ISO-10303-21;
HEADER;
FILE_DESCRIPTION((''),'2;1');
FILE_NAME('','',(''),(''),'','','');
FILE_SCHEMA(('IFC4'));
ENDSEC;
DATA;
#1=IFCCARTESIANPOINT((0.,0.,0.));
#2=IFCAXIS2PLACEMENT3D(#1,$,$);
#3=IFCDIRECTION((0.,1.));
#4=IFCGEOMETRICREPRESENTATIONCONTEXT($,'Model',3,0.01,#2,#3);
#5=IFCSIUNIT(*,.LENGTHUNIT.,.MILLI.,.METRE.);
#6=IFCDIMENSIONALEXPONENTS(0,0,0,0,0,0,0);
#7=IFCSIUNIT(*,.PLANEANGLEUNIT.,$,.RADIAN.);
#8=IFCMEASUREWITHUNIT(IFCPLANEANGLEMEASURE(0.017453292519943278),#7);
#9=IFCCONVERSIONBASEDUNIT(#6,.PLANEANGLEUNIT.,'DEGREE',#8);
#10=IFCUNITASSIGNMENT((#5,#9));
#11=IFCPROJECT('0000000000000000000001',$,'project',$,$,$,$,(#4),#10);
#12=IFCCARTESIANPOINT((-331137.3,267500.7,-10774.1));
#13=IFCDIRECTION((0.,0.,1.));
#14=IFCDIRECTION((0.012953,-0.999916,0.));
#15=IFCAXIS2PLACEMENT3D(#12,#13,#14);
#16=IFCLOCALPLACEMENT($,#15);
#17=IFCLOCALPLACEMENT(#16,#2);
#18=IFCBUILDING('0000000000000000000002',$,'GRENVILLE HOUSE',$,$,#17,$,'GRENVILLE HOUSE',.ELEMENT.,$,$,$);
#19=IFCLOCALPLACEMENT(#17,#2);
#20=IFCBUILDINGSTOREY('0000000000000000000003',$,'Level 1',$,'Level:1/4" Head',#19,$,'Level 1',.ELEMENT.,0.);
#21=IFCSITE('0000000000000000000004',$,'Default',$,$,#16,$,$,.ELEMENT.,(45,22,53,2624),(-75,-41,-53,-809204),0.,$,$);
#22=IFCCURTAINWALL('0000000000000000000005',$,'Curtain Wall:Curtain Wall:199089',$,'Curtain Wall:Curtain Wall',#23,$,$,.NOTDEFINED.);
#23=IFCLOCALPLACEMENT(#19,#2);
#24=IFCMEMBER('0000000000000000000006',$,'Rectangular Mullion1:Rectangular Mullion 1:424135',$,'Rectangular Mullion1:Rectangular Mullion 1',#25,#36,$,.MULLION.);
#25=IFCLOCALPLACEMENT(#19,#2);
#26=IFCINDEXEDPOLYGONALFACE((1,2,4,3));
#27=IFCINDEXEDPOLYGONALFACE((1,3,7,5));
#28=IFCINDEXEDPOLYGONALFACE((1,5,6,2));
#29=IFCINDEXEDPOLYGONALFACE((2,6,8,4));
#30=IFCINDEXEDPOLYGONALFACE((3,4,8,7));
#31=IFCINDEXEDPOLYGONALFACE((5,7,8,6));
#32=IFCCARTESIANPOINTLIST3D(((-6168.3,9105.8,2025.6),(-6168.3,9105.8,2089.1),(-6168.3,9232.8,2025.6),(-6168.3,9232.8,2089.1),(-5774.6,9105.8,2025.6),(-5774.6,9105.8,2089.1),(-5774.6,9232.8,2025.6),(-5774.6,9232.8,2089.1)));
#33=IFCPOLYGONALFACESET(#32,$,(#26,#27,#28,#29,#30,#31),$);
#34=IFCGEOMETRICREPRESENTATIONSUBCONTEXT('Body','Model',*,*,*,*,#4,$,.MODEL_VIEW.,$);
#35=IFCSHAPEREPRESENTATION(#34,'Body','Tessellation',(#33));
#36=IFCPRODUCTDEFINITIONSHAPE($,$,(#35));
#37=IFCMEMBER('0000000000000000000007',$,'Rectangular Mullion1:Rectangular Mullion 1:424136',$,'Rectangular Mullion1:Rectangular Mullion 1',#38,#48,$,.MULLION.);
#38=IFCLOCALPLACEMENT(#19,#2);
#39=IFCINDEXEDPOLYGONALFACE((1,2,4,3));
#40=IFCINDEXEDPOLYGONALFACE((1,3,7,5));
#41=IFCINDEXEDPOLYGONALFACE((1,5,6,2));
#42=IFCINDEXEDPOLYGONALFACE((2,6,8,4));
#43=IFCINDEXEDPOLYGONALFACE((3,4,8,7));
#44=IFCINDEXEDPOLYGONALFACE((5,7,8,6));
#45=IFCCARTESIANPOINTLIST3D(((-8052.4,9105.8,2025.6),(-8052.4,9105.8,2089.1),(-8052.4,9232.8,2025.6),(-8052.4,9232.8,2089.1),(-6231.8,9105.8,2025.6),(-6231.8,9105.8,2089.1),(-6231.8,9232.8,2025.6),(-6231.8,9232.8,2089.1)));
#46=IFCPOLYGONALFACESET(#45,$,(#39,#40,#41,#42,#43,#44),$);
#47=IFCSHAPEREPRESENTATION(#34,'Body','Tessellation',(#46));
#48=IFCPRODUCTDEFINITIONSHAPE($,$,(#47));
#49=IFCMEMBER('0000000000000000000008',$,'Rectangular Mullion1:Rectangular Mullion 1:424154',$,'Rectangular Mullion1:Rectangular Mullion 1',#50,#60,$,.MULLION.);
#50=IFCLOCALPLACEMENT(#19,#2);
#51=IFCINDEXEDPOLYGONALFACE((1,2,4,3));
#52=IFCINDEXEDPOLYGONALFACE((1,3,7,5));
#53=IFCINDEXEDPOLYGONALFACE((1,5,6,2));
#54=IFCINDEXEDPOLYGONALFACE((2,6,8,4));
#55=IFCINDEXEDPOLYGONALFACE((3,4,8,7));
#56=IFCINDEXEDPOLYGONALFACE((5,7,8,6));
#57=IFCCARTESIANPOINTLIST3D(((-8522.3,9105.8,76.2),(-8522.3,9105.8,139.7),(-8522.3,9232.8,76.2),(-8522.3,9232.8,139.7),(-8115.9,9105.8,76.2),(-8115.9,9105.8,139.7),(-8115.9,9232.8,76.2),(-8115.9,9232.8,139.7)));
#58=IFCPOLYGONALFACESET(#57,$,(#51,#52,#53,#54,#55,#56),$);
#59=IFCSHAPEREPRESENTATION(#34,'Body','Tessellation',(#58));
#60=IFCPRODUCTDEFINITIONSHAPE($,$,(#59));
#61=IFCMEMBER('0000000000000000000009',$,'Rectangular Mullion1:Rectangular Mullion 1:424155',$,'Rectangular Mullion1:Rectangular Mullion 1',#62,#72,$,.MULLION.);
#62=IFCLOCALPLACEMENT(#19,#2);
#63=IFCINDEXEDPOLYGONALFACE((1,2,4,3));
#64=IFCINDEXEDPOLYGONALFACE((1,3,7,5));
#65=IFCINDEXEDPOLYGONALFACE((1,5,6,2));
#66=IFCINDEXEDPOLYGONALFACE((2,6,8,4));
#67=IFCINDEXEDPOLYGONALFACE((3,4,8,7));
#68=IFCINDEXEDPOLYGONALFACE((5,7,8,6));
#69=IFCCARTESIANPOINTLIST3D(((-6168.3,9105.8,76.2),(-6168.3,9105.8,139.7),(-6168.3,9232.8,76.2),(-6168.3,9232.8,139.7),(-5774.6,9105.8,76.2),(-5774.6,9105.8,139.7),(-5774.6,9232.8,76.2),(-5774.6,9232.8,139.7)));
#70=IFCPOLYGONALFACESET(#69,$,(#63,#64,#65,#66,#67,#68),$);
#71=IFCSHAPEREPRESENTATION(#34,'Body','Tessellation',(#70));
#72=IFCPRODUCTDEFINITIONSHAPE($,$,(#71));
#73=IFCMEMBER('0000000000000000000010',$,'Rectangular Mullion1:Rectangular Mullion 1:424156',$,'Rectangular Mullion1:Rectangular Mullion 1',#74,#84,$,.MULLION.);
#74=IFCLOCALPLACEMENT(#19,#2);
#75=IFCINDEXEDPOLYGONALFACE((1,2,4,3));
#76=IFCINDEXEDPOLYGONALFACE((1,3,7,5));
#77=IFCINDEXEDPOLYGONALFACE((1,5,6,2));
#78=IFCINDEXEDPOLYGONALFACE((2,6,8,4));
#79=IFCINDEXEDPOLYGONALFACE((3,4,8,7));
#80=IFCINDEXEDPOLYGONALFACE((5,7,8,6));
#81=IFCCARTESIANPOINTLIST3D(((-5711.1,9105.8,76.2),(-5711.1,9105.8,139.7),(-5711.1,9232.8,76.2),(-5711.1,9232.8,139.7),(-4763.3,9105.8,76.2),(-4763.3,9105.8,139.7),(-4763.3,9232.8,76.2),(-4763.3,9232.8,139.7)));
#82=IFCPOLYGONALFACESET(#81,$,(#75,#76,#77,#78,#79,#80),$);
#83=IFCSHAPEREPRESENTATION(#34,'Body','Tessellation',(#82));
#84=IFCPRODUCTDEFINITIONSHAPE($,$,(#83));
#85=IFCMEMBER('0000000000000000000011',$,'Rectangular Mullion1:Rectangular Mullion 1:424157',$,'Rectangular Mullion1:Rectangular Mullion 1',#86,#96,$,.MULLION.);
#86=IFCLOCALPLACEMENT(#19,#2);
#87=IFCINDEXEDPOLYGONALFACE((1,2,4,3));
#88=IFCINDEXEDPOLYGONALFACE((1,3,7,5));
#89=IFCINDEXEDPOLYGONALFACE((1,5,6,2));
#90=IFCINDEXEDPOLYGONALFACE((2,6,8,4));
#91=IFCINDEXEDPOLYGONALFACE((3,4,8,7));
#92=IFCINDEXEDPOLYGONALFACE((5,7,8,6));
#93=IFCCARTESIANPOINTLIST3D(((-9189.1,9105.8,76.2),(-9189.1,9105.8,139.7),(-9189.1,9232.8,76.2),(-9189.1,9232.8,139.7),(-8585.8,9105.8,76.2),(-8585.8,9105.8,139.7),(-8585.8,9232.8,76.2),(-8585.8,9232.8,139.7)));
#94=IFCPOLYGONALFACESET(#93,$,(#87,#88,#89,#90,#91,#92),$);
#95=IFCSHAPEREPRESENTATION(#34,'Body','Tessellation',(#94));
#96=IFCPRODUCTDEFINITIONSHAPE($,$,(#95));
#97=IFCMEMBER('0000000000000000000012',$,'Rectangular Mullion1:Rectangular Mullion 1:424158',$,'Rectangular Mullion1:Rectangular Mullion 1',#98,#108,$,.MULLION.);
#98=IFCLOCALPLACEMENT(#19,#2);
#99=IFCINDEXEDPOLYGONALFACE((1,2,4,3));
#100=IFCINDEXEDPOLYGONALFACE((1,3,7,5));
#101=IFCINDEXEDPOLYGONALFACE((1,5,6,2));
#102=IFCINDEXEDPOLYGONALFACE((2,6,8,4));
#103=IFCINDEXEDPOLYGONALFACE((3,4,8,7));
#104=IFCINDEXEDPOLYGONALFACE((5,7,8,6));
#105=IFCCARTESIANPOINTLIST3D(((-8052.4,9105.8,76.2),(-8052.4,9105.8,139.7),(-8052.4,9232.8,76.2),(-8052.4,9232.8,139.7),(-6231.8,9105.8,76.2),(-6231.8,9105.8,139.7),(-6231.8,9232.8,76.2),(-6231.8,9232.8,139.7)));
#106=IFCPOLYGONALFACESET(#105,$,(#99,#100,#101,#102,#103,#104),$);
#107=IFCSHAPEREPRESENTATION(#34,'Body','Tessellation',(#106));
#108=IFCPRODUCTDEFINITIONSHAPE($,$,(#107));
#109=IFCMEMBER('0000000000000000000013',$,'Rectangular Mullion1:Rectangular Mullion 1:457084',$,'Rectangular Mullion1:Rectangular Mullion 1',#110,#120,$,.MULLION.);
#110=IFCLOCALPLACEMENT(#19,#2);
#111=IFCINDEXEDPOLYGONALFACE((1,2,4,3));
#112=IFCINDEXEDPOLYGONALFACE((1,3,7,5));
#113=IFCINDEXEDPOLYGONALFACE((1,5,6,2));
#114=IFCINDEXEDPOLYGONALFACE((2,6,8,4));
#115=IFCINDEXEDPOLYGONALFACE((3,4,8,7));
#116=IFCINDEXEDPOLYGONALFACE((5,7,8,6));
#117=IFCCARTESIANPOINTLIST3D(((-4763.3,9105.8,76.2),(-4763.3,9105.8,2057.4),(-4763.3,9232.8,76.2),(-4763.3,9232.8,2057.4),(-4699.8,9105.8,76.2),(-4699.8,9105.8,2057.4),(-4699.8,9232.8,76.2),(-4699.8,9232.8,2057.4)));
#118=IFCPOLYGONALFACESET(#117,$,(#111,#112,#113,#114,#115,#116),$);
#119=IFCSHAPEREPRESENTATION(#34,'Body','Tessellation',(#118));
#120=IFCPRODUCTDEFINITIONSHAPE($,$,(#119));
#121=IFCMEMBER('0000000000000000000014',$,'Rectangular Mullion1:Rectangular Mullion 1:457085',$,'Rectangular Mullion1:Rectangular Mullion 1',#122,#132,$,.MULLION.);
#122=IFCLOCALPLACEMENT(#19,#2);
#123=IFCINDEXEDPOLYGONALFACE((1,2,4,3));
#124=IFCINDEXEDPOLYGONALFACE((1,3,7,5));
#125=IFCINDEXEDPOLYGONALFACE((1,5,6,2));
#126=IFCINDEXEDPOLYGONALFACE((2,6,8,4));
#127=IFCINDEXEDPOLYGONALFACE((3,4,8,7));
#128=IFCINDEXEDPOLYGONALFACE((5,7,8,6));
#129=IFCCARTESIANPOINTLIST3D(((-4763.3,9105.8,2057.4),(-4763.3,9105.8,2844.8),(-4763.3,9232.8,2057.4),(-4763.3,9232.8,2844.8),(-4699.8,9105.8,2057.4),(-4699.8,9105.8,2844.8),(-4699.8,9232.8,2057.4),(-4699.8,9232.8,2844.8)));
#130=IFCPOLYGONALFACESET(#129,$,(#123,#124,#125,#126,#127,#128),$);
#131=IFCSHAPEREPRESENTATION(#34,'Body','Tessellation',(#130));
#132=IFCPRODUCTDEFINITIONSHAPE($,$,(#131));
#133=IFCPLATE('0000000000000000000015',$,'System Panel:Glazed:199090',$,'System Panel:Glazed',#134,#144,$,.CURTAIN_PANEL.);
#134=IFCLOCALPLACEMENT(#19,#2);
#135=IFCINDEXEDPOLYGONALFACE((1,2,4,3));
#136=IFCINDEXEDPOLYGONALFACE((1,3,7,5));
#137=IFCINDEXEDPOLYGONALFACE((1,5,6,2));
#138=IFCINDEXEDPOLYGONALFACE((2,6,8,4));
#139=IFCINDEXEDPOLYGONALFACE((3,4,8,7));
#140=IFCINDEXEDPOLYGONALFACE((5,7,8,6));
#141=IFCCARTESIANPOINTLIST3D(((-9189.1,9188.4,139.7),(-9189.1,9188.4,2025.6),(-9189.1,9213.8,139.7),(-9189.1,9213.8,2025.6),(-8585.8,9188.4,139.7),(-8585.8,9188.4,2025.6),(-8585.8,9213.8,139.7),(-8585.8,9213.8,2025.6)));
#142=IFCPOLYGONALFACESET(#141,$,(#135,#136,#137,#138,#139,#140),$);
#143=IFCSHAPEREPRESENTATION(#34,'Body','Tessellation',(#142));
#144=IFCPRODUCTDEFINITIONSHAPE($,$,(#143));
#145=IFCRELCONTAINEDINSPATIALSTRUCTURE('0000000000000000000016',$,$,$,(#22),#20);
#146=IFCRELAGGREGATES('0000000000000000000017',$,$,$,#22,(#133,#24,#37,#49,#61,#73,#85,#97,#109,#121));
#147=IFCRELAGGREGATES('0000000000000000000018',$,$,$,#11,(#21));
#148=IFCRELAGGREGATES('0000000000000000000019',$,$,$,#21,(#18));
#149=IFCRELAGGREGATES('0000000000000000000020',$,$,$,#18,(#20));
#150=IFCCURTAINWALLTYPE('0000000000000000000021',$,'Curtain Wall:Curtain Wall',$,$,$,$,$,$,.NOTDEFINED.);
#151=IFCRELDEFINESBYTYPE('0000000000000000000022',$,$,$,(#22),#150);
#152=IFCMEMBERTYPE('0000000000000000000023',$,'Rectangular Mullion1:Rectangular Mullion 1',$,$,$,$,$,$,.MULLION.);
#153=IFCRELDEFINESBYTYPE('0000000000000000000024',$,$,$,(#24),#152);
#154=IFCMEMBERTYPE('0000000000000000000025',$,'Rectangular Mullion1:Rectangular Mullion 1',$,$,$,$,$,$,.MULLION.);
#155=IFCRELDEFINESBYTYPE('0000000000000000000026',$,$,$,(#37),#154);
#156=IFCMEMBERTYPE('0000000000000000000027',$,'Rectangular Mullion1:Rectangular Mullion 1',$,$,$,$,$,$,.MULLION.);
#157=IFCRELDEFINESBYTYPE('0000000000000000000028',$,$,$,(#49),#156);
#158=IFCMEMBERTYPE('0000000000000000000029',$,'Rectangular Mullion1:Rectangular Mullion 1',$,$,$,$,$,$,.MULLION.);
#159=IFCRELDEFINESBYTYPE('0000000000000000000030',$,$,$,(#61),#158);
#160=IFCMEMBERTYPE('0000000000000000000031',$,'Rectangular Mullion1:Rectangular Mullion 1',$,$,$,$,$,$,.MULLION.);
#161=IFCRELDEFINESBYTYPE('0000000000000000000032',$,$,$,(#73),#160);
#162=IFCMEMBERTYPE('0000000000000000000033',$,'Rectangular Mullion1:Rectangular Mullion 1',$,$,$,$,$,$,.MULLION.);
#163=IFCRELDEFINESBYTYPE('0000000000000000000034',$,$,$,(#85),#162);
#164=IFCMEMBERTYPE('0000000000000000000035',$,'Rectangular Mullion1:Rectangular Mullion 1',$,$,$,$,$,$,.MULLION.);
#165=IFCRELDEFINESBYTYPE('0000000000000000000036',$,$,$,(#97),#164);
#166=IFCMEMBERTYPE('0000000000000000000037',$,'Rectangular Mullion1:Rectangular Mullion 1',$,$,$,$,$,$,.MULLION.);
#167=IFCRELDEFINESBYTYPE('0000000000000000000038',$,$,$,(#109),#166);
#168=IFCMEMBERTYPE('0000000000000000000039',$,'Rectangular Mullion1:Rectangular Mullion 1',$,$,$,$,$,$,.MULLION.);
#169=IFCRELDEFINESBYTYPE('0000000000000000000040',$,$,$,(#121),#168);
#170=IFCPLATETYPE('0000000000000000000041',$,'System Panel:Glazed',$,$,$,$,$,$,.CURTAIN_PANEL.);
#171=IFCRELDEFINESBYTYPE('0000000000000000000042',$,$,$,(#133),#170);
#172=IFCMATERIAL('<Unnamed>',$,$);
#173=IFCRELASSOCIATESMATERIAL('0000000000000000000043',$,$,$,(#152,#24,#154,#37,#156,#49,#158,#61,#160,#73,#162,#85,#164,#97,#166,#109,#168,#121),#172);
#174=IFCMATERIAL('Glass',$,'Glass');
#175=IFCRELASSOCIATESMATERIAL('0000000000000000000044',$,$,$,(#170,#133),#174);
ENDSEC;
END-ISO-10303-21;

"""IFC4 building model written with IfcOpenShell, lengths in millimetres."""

from ifc_helpers import new_model, entity, si_unit, converted_unit, direction, frame, origin, place, context, subcontext, project, spatial, indexed_curve, outline, extrude, source, transform, mapped, material, type_object, type_shapes, element, aggregate, save


model = new_model("IFC4")

# Units and contexts
model_context = context("Model", 3, precision=0.01, world=origin(), true_north=direction((0.0, 1.0)))
body_context = subcontext(model_context, "Body", "Model", "MODEL_VIEW")
ifc_project = project(units=[si_unit("LENGTHUNIT", "METRE", prefix="MILLI"), converted_unit("PLANEANGLEUNIT", "DEGREE", entity("IfcPlaneAngleMeasure", 0.017453292519943278), si_unit("PLANEANGLEUNIT", "RADIAN"), dimensions=[0, 0, 0, 0, 0, 0, 0])], contexts=[model_context])

# Site, building, storey
site_placement = place(None, frame((-331137.3, 267500.7, -10774.1), z_axis=(0.0, 0.0, 1.0), x_axis=(0.012953, -0.999916, 0.0)))
site = spatial("IfcSite", under=ifc_project, at=site_placement, Name="Default", CompositionType="ELEMENT", RefLatitude=(45, 22, 53, 2624), RefLongitude=(-75, -41, -53, -809204), RefElevation=0.0)
building_placement = place(site_placement, origin())
building = spatial("IfcBuilding", under=site, at=building_placement, Name="GRENVILLE HOUSE", LongName="GRENVILLE HOUSE", CompositionType="ELEMENT")
storey_placement = place(building_placement, origin())
storey = spatial("IfcBuildingStorey", under=building, at=storey_placement, Name="Level 1", ObjectType="Level:1/4\" Head", LongName="Level 1", CompositionType="ELEMENT", Elevation=0.0)

# Shared definitions
curtain_wall_type = type_object("IfcCurtainWallType", Name="Curtain Wall:Curtain Wall", PredefinedType="NOTDEFINED")
ifc_material_1 = material(Name="<Unnamed>")

# Curtain wall, members, plate
curtain_wall_1_placement = place(storey_placement, origin())
curtain_wall_1 = element("IfcCurtainWall", 1, at=curtain_wall_1_placement, inside=storey, type_object=curtain_wall_type, Name="Curtain Wall:Curtain Wall:199089", ObjectType="Curtain Wall:Curtain Wall", PredefinedType="NOTDEFINED")
member_type_1 = type_object("IfcMemberType", Name="Rectangular Mullion1:Rectangular Mullion 1", PredefinedType="MULLION", material=ifc_material_1)
shared_shape_1 = source(origin(), body_context, "Body", "SweptSolid", [
    extrude(outline(indexed_curve([(-31.8, -63.5), (31.8, -63.5), (31.8, 63.5), (-31.8, 63.5), (-31.8, -63.5)], self_intersect=False)), frame((0.0, 0.0, -393.7), z_axis=(0.0, 0.0, 1.0), x_axis=(-1.0, 0.0, 0.0)), (0.0, 0.0, 1.0), 393.7),
])
type_shapes(member_type_1, [shared_shape_1])
member_1_placement = place(curtain_wall_1_placement, frame((-5774.6, 9169.3, 2057.4), z_axis=(1.0, 0.0, 0.0), x_axis=(0.0, 0.0, 1.0)))
member_1 = element("IfcMember", 2, at=member_1_placement, type_object=member_type_1, material=ifc_material_1, Name="Rectangular Mullion1:Rectangular Mullion 1:424135", ObjectType="Rectangular Mullion1:Rectangular Mullion 1", PredefinedType="MULLION", context=body_context, shape_type="MappedRepresentation", body=[
    mapped(shared_shape_1, transform((0.0, 0.0, 0.0), scale=1.0)),
])
member_type_2 = type_object("IfcMemberType", Name="Rectangular Mullion1:Rectangular Mullion 1", PredefinedType="MULLION", material=ifc_material_1)
shared_shape_2 = source(origin(), body_context, "Body", "SweptSolid", [
    extrude(outline(indexed_curve([(-31.8, -63.5), (31.8, -63.5), (31.8, 63.5), (-31.8, 63.5), (-31.8, -63.5)], self_intersect=False)), frame((0.0, 0.0, -1820.6), z_axis=(0.0, 0.0, 1.0), x_axis=(-1.0, 0.0, 0.0)), (0.0, 0.0, 1.0), 1820.6),
])
type_shapes(member_type_2, [shared_shape_2])
member_2_placement = place(curtain_wall_1_placement, frame((-6231.8, 9169.3, 2057.4), z_axis=(1.0, 0.0, 0.0), x_axis=(0.0, 0.0, 1.0)))
member_2 = element("IfcMember", 3, at=member_2_placement, type_object=member_type_2, material=ifc_material_1, Name="Rectangular Mullion1:Rectangular Mullion 1:424136", ObjectType="Rectangular Mullion1:Rectangular Mullion 1", PredefinedType="MULLION", context=body_context, shape_type="MappedRepresentation", body=[
    mapped(shared_shape_2, transform((0.0, 0.0, 0.0), scale=1.0)),
])
member_type_3 = type_object("IfcMemberType", Name="Rectangular Mullion1:Rectangular Mullion 1", PredefinedType="MULLION", material=ifc_material_1)
shared_shape_3 = source(origin(), body_context, "Body", "SweptSolid", [
    extrude(outline(indexed_curve([(-31.8, -63.5), (31.8, -63.5), (31.8, 63.5), (-31.8, 63.5), (-31.8, -63.5)], self_intersect=False)), frame((-31.8, 0.0, -406.4), z_axis=(0.0, 0.0, 1.0), x_axis=(-1.0, 0.0, 0.0)), (0.0, 0.0, 1.0), 406.4),
])
type_shapes(member_type_3, [shared_shape_3])
member_3_placement = place(curtain_wall_1_placement, frame((-8522.3, 9169.3, 76.2), z_axis=(-1.0, 0.0, 0.0), x_axis=(0.0, 0.0, -1.0)))
member_3 = element("IfcMember", 4, at=member_3_placement, type_object=member_type_3, material=ifc_material_1, Name="Rectangular Mullion1:Rectangular Mullion 1:424154", ObjectType="Rectangular Mullion1:Rectangular Mullion 1", PredefinedType="MULLION", context=body_context, shape_type="MappedRepresentation", body=[
    mapped(shared_shape_3, transform((0.0, 0.0, 0.0), scale=1.0)),
])
member_type_4 = type_object("IfcMemberType", Name="Rectangular Mullion1:Rectangular Mullion 1", PredefinedType="MULLION", material=ifc_material_1)
shared_shape_4 = source(origin(), body_context, "Body", "SweptSolid", [
    extrude(outline(indexed_curve([(-31.8, -63.5), (31.8, -63.5), (31.8, 63.5), (-31.8, 63.5), (-31.8, -63.5)], self_intersect=False)), frame((-31.8, 0.0, -393.7), z_axis=(0.0, 0.0, 1.0), x_axis=(-1.0, 0.0, 0.0)), (0.0, 0.0, 1.0), 393.7),
])
type_shapes(member_type_4, [shared_shape_4])
member_4_placement = place(curtain_wall_1_placement, frame((-6168.3, 9169.3, 76.2), z_axis=(-1.0, 0.0, 0.0), x_axis=(0.0, 0.0, -1.0)))
member_4 = element("IfcMember", 5, at=member_4_placement, type_object=member_type_4, material=ifc_material_1, Name="Rectangular Mullion1:Rectangular Mullion 1:424155", ObjectType="Rectangular Mullion1:Rectangular Mullion 1", PredefinedType="MULLION", context=body_context, shape_type="MappedRepresentation", body=[
    mapped(shared_shape_4, transform((0.0, 0.0, 0.0), scale=1.0)),
])
member_type_5 = type_object("IfcMemberType", Name="Rectangular Mullion1:Rectangular Mullion 1", PredefinedType="MULLION", material=ifc_material_1)
shared_shape_5 = source(origin(), body_context, "Body", "SweptSolid", [
    extrude(outline(indexed_curve([(-31.8, -63.5), (31.8, -63.5), (31.8, 63.5), (-31.8, 63.5), (-31.8, -63.5)], self_intersect=False)), frame((-31.8, 0.0, -947.7), z_axis=(0.0, 0.0, 1.0), x_axis=(-1.0, 0.0, 0.0)), (0.0, 0.0, 1.0), 947.7),
])
type_shapes(member_type_5, [shared_shape_5])
member_5_placement = place(curtain_wall_1_placement, frame((-5711.1, 9169.3, 76.2), z_axis=(-1.0, 0.0, 0.0), x_axis=(0.0, 0.0, -1.0)))
member_5 = element("IfcMember", 6, at=member_5_placement, type_object=member_type_5, material=ifc_material_1, Name="Rectangular Mullion1:Rectangular Mullion 1:424156", ObjectType="Rectangular Mullion1:Rectangular Mullion 1", PredefinedType="MULLION", context=body_context, shape_type="MappedRepresentation", body=[
    mapped(shared_shape_5, transform((0.0, 0.0, 0.0), scale=1.0)),
])
member_type_6 = type_object("IfcMemberType", Name="Rectangular Mullion1:Rectangular Mullion 1", PredefinedType="MULLION", material=ifc_material_1)
shared_shape_6 = source(origin(), body_context, "Body", "SweptSolid", [
    extrude(outline(indexed_curve([(-31.8, -63.5), (31.8, -63.5), (31.8, 63.5), (-31.8, 63.5), (-31.8, -63.5)], self_intersect=False)), frame((-31.8, 0.0, -603.3), z_axis=(0.0, 0.0, 1.0), x_axis=(-1.0, 0.0, 0.0)), (0.0, 0.0, 1.0), 603.3),
])
type_shapes(member_type_6, [shared_shape_6])
member_6_placement = place(curtain_wall_1_placement, frame((-9189.1, 9169.3, 76.2), z_axis=(-1.0, 0.0, 0.0), x_axis=(0.0, 0.0, -1.0)))
member_6 = element("IfcMember", 7, at=member_6_placement, type_object=member_type_6, material=ifc_material_1, Name="Rectangular Mullion1:Rectangular Mullion 1:424157", ObjectType="Rectangular Mullion1:Rectangular Mullion 1", PredefinedType="MULLION", context=body_context, shape_type="MappedRepresentation", body=[
    mapped(shared_shape_6, transform((0.0, 0.0, 0.0), scale=1.0)),
])
member_type_7 = type_object("IfcMemberType", Name="Rectangular Mullion1:Rectangular Mullion 1", PredefinedType="MULLION", material=ifc_material_1)
shared_shape_7 = source(origin(), body_context, "Body", "SweptSolid", [
    extrude(outline(indexed_curve([(-31.8, -63.5), (31.8, -63.5), (31.8, 63.5), (-31.8, 63.5), (-31.8, -63.5)], self_intersect=False)), frame((-31.8, 0.0, -1820.6), z_axis=(0.0, 0.0, 1.0), x_axis=(-1.0, 0.0, 0.0)), (0.0, 0.0, 1.0), 1820.6),
])
type_shapes(member_type_7, [shared_shape_7])
member_7_placement = place(curtain_wall_1_placement, frame((-8052.4, 9169.3, 76.2), z_axis=(-1.0, 0.0, 0.0), x_axis=(0.0, 0.0, -1.0)))
member_7 = element("IfcMember", 8, at=member_7_placement, type_object=member_type_7, material=ifc_material_1, Name="Rectangular Mullion1:Rectangular Mullion 1:424158", ObjectType="Rectangular Mullion1:Rectangular Mullion 1", PredefinedType="MULLION", context=body_context, shape_type="MappedRepresentation", body=[
    mapped(shared_shape_7, transform((0.0, 0.0, 0.0), scale=1.0)),
])
member_type_8 = type_object("IfcMemberType", Name="Rectangular Mullion1:Rectangular Mullion 1", PredefinedType="MULLION", material=ifc_material_1)
shared_shape_8 = source(origin(), body_context, "Body", "SweptSolid", [
    extrude(outline(indexed_curve([(-31.8, -63.5), (31.8, -63.5), (31.8, 63.5), (-31.8, 63.5), (-31.8, -63.5)], self_intersect=False)), frame((-31.8, 0.0, -1981.2), z_axis=(0.0, 0.0, 1.0), x_axis=(-1.0, 0.0, 0.0)), (0.0, 0.0, 1.0), 1981.2),
])
type_shapes(member_type_8, [shared_shape_8])
member_8_placement = place(curtain_wall_1_placement, frame((-4699.8, 9169.3, 76.2), z_axis=(0.0, 0.0, -1.0), x_axis=(1.0, 0.0, 0.0)))
member_8 = element("IfcMember", 9, at=member_8_placement, type_object=member_type_8, material=ifc_material_1, Name="Rectangular Mullion1:Rectangular Mullion 1:457084", ObjectType="Rectangular Mullion1:Rectangular Mullion 1", PredefinedType="MULLION", context=body_context, shape_type="MappedRepresentation", body=[
    mapped(shared_shape_8, transform((0.0, 0.0, 0.0), scale=1.0)),
])
member_type_9 = type_object("IfcMemberType", Name="Rectangular Mullion1:Rectangular Mullion 1", PredefinedType="MULLION", material=ifc_material_1)
shared_shape_9 = source(origin(), body_context, "Body", "SweptSolid", [
    extrude(outline(indexed_curve([(-31.8, -63.5), (31.8, -63.5), (31.8, 63.5), (-31.8, 63.5), (-31.8, -63.5)], self_intersect=False)), frame((-31.8, 0.0, -787.4), z_axis=(0.0, 0.0, 1.0), x_axis=(-1.0, 0.0, 0.0)), (0.0, 0.0, 1.0), 787.4),
])
type_shapes(member_type_9, [shared_shape_9])
member_9_placement = place(curtain_wall_1_placement, frame((-4699.8, 9169.3, 2057.4), z_axis=(0.0, 0.0, -1.0), x_axis=(1.0, 0.0, 0.0)))
member_9 = element("IfcMember", 10, at=member_9_placement, type_object=member_type_9, material=ifc_material_1, Name="Rectangular Mullion1:Rectangular Mullion 1:457085", ObjectType="Rectangular Mullion1:Rectangular Mullion 1", PredefinedType="MULLION", context=body_context, shape_type="MappedRepresentation", body=[
    mapped(shared_shape_9, transform((0.0, 0.0, 0.0), scale=1.0)),
])
ifc_material_2 = material(Name="Glass", Category="Glass")
plate_type_1 = type_object("IfcPlateType", Name="System Panel:Glazed", PredefinedType="CURTAIN_PANEL", material=ifc_material_2)
shared_shape_10 = source(origin(), body_context, "Body", "SweptSolid", [
    extrude(outline(indexed_curve([(-12.7, -301.6), (12.7, -301.6), (12.7, 301.6), (-12.7, 301.6), (-12.7, -301.6)], self_intersect=False)), frame((301.6, 12.7, 0.0), z_axis=(0.0, 0.0, 1.0), x_axis=(0.0, 1.0, 0.0)), (0.0, 0.0, 1.0), 1885.9),
])
type_shapes(plate_type_1, [shared_shape_10])
plate_1_placement = place(curtain_wall_1_placement, frame((-9189.1, 9188.4, 139.7)))
plate_1 = element("IfcPlate", 11, at=plate_1_placement, type_object=plate_type_1, material=ifc_material_2, Name="System Panel:Glazed:199090", ObjectType="System Panel:Glazed", PredefinedType="CURTAIN_PANEL", context=body_context, shape_type="MappedRepresentation", body=[
    mapped(shared_shape_10, transform((0.0, 0.0, 0.0), scale=1.0)),
])

aggregate(curtain_wall_1, [plate_1, member_1, member_2, member_3, member_4, member_5, member_6, member_7, member_8, member_9])

save(model, "model.ifc")
